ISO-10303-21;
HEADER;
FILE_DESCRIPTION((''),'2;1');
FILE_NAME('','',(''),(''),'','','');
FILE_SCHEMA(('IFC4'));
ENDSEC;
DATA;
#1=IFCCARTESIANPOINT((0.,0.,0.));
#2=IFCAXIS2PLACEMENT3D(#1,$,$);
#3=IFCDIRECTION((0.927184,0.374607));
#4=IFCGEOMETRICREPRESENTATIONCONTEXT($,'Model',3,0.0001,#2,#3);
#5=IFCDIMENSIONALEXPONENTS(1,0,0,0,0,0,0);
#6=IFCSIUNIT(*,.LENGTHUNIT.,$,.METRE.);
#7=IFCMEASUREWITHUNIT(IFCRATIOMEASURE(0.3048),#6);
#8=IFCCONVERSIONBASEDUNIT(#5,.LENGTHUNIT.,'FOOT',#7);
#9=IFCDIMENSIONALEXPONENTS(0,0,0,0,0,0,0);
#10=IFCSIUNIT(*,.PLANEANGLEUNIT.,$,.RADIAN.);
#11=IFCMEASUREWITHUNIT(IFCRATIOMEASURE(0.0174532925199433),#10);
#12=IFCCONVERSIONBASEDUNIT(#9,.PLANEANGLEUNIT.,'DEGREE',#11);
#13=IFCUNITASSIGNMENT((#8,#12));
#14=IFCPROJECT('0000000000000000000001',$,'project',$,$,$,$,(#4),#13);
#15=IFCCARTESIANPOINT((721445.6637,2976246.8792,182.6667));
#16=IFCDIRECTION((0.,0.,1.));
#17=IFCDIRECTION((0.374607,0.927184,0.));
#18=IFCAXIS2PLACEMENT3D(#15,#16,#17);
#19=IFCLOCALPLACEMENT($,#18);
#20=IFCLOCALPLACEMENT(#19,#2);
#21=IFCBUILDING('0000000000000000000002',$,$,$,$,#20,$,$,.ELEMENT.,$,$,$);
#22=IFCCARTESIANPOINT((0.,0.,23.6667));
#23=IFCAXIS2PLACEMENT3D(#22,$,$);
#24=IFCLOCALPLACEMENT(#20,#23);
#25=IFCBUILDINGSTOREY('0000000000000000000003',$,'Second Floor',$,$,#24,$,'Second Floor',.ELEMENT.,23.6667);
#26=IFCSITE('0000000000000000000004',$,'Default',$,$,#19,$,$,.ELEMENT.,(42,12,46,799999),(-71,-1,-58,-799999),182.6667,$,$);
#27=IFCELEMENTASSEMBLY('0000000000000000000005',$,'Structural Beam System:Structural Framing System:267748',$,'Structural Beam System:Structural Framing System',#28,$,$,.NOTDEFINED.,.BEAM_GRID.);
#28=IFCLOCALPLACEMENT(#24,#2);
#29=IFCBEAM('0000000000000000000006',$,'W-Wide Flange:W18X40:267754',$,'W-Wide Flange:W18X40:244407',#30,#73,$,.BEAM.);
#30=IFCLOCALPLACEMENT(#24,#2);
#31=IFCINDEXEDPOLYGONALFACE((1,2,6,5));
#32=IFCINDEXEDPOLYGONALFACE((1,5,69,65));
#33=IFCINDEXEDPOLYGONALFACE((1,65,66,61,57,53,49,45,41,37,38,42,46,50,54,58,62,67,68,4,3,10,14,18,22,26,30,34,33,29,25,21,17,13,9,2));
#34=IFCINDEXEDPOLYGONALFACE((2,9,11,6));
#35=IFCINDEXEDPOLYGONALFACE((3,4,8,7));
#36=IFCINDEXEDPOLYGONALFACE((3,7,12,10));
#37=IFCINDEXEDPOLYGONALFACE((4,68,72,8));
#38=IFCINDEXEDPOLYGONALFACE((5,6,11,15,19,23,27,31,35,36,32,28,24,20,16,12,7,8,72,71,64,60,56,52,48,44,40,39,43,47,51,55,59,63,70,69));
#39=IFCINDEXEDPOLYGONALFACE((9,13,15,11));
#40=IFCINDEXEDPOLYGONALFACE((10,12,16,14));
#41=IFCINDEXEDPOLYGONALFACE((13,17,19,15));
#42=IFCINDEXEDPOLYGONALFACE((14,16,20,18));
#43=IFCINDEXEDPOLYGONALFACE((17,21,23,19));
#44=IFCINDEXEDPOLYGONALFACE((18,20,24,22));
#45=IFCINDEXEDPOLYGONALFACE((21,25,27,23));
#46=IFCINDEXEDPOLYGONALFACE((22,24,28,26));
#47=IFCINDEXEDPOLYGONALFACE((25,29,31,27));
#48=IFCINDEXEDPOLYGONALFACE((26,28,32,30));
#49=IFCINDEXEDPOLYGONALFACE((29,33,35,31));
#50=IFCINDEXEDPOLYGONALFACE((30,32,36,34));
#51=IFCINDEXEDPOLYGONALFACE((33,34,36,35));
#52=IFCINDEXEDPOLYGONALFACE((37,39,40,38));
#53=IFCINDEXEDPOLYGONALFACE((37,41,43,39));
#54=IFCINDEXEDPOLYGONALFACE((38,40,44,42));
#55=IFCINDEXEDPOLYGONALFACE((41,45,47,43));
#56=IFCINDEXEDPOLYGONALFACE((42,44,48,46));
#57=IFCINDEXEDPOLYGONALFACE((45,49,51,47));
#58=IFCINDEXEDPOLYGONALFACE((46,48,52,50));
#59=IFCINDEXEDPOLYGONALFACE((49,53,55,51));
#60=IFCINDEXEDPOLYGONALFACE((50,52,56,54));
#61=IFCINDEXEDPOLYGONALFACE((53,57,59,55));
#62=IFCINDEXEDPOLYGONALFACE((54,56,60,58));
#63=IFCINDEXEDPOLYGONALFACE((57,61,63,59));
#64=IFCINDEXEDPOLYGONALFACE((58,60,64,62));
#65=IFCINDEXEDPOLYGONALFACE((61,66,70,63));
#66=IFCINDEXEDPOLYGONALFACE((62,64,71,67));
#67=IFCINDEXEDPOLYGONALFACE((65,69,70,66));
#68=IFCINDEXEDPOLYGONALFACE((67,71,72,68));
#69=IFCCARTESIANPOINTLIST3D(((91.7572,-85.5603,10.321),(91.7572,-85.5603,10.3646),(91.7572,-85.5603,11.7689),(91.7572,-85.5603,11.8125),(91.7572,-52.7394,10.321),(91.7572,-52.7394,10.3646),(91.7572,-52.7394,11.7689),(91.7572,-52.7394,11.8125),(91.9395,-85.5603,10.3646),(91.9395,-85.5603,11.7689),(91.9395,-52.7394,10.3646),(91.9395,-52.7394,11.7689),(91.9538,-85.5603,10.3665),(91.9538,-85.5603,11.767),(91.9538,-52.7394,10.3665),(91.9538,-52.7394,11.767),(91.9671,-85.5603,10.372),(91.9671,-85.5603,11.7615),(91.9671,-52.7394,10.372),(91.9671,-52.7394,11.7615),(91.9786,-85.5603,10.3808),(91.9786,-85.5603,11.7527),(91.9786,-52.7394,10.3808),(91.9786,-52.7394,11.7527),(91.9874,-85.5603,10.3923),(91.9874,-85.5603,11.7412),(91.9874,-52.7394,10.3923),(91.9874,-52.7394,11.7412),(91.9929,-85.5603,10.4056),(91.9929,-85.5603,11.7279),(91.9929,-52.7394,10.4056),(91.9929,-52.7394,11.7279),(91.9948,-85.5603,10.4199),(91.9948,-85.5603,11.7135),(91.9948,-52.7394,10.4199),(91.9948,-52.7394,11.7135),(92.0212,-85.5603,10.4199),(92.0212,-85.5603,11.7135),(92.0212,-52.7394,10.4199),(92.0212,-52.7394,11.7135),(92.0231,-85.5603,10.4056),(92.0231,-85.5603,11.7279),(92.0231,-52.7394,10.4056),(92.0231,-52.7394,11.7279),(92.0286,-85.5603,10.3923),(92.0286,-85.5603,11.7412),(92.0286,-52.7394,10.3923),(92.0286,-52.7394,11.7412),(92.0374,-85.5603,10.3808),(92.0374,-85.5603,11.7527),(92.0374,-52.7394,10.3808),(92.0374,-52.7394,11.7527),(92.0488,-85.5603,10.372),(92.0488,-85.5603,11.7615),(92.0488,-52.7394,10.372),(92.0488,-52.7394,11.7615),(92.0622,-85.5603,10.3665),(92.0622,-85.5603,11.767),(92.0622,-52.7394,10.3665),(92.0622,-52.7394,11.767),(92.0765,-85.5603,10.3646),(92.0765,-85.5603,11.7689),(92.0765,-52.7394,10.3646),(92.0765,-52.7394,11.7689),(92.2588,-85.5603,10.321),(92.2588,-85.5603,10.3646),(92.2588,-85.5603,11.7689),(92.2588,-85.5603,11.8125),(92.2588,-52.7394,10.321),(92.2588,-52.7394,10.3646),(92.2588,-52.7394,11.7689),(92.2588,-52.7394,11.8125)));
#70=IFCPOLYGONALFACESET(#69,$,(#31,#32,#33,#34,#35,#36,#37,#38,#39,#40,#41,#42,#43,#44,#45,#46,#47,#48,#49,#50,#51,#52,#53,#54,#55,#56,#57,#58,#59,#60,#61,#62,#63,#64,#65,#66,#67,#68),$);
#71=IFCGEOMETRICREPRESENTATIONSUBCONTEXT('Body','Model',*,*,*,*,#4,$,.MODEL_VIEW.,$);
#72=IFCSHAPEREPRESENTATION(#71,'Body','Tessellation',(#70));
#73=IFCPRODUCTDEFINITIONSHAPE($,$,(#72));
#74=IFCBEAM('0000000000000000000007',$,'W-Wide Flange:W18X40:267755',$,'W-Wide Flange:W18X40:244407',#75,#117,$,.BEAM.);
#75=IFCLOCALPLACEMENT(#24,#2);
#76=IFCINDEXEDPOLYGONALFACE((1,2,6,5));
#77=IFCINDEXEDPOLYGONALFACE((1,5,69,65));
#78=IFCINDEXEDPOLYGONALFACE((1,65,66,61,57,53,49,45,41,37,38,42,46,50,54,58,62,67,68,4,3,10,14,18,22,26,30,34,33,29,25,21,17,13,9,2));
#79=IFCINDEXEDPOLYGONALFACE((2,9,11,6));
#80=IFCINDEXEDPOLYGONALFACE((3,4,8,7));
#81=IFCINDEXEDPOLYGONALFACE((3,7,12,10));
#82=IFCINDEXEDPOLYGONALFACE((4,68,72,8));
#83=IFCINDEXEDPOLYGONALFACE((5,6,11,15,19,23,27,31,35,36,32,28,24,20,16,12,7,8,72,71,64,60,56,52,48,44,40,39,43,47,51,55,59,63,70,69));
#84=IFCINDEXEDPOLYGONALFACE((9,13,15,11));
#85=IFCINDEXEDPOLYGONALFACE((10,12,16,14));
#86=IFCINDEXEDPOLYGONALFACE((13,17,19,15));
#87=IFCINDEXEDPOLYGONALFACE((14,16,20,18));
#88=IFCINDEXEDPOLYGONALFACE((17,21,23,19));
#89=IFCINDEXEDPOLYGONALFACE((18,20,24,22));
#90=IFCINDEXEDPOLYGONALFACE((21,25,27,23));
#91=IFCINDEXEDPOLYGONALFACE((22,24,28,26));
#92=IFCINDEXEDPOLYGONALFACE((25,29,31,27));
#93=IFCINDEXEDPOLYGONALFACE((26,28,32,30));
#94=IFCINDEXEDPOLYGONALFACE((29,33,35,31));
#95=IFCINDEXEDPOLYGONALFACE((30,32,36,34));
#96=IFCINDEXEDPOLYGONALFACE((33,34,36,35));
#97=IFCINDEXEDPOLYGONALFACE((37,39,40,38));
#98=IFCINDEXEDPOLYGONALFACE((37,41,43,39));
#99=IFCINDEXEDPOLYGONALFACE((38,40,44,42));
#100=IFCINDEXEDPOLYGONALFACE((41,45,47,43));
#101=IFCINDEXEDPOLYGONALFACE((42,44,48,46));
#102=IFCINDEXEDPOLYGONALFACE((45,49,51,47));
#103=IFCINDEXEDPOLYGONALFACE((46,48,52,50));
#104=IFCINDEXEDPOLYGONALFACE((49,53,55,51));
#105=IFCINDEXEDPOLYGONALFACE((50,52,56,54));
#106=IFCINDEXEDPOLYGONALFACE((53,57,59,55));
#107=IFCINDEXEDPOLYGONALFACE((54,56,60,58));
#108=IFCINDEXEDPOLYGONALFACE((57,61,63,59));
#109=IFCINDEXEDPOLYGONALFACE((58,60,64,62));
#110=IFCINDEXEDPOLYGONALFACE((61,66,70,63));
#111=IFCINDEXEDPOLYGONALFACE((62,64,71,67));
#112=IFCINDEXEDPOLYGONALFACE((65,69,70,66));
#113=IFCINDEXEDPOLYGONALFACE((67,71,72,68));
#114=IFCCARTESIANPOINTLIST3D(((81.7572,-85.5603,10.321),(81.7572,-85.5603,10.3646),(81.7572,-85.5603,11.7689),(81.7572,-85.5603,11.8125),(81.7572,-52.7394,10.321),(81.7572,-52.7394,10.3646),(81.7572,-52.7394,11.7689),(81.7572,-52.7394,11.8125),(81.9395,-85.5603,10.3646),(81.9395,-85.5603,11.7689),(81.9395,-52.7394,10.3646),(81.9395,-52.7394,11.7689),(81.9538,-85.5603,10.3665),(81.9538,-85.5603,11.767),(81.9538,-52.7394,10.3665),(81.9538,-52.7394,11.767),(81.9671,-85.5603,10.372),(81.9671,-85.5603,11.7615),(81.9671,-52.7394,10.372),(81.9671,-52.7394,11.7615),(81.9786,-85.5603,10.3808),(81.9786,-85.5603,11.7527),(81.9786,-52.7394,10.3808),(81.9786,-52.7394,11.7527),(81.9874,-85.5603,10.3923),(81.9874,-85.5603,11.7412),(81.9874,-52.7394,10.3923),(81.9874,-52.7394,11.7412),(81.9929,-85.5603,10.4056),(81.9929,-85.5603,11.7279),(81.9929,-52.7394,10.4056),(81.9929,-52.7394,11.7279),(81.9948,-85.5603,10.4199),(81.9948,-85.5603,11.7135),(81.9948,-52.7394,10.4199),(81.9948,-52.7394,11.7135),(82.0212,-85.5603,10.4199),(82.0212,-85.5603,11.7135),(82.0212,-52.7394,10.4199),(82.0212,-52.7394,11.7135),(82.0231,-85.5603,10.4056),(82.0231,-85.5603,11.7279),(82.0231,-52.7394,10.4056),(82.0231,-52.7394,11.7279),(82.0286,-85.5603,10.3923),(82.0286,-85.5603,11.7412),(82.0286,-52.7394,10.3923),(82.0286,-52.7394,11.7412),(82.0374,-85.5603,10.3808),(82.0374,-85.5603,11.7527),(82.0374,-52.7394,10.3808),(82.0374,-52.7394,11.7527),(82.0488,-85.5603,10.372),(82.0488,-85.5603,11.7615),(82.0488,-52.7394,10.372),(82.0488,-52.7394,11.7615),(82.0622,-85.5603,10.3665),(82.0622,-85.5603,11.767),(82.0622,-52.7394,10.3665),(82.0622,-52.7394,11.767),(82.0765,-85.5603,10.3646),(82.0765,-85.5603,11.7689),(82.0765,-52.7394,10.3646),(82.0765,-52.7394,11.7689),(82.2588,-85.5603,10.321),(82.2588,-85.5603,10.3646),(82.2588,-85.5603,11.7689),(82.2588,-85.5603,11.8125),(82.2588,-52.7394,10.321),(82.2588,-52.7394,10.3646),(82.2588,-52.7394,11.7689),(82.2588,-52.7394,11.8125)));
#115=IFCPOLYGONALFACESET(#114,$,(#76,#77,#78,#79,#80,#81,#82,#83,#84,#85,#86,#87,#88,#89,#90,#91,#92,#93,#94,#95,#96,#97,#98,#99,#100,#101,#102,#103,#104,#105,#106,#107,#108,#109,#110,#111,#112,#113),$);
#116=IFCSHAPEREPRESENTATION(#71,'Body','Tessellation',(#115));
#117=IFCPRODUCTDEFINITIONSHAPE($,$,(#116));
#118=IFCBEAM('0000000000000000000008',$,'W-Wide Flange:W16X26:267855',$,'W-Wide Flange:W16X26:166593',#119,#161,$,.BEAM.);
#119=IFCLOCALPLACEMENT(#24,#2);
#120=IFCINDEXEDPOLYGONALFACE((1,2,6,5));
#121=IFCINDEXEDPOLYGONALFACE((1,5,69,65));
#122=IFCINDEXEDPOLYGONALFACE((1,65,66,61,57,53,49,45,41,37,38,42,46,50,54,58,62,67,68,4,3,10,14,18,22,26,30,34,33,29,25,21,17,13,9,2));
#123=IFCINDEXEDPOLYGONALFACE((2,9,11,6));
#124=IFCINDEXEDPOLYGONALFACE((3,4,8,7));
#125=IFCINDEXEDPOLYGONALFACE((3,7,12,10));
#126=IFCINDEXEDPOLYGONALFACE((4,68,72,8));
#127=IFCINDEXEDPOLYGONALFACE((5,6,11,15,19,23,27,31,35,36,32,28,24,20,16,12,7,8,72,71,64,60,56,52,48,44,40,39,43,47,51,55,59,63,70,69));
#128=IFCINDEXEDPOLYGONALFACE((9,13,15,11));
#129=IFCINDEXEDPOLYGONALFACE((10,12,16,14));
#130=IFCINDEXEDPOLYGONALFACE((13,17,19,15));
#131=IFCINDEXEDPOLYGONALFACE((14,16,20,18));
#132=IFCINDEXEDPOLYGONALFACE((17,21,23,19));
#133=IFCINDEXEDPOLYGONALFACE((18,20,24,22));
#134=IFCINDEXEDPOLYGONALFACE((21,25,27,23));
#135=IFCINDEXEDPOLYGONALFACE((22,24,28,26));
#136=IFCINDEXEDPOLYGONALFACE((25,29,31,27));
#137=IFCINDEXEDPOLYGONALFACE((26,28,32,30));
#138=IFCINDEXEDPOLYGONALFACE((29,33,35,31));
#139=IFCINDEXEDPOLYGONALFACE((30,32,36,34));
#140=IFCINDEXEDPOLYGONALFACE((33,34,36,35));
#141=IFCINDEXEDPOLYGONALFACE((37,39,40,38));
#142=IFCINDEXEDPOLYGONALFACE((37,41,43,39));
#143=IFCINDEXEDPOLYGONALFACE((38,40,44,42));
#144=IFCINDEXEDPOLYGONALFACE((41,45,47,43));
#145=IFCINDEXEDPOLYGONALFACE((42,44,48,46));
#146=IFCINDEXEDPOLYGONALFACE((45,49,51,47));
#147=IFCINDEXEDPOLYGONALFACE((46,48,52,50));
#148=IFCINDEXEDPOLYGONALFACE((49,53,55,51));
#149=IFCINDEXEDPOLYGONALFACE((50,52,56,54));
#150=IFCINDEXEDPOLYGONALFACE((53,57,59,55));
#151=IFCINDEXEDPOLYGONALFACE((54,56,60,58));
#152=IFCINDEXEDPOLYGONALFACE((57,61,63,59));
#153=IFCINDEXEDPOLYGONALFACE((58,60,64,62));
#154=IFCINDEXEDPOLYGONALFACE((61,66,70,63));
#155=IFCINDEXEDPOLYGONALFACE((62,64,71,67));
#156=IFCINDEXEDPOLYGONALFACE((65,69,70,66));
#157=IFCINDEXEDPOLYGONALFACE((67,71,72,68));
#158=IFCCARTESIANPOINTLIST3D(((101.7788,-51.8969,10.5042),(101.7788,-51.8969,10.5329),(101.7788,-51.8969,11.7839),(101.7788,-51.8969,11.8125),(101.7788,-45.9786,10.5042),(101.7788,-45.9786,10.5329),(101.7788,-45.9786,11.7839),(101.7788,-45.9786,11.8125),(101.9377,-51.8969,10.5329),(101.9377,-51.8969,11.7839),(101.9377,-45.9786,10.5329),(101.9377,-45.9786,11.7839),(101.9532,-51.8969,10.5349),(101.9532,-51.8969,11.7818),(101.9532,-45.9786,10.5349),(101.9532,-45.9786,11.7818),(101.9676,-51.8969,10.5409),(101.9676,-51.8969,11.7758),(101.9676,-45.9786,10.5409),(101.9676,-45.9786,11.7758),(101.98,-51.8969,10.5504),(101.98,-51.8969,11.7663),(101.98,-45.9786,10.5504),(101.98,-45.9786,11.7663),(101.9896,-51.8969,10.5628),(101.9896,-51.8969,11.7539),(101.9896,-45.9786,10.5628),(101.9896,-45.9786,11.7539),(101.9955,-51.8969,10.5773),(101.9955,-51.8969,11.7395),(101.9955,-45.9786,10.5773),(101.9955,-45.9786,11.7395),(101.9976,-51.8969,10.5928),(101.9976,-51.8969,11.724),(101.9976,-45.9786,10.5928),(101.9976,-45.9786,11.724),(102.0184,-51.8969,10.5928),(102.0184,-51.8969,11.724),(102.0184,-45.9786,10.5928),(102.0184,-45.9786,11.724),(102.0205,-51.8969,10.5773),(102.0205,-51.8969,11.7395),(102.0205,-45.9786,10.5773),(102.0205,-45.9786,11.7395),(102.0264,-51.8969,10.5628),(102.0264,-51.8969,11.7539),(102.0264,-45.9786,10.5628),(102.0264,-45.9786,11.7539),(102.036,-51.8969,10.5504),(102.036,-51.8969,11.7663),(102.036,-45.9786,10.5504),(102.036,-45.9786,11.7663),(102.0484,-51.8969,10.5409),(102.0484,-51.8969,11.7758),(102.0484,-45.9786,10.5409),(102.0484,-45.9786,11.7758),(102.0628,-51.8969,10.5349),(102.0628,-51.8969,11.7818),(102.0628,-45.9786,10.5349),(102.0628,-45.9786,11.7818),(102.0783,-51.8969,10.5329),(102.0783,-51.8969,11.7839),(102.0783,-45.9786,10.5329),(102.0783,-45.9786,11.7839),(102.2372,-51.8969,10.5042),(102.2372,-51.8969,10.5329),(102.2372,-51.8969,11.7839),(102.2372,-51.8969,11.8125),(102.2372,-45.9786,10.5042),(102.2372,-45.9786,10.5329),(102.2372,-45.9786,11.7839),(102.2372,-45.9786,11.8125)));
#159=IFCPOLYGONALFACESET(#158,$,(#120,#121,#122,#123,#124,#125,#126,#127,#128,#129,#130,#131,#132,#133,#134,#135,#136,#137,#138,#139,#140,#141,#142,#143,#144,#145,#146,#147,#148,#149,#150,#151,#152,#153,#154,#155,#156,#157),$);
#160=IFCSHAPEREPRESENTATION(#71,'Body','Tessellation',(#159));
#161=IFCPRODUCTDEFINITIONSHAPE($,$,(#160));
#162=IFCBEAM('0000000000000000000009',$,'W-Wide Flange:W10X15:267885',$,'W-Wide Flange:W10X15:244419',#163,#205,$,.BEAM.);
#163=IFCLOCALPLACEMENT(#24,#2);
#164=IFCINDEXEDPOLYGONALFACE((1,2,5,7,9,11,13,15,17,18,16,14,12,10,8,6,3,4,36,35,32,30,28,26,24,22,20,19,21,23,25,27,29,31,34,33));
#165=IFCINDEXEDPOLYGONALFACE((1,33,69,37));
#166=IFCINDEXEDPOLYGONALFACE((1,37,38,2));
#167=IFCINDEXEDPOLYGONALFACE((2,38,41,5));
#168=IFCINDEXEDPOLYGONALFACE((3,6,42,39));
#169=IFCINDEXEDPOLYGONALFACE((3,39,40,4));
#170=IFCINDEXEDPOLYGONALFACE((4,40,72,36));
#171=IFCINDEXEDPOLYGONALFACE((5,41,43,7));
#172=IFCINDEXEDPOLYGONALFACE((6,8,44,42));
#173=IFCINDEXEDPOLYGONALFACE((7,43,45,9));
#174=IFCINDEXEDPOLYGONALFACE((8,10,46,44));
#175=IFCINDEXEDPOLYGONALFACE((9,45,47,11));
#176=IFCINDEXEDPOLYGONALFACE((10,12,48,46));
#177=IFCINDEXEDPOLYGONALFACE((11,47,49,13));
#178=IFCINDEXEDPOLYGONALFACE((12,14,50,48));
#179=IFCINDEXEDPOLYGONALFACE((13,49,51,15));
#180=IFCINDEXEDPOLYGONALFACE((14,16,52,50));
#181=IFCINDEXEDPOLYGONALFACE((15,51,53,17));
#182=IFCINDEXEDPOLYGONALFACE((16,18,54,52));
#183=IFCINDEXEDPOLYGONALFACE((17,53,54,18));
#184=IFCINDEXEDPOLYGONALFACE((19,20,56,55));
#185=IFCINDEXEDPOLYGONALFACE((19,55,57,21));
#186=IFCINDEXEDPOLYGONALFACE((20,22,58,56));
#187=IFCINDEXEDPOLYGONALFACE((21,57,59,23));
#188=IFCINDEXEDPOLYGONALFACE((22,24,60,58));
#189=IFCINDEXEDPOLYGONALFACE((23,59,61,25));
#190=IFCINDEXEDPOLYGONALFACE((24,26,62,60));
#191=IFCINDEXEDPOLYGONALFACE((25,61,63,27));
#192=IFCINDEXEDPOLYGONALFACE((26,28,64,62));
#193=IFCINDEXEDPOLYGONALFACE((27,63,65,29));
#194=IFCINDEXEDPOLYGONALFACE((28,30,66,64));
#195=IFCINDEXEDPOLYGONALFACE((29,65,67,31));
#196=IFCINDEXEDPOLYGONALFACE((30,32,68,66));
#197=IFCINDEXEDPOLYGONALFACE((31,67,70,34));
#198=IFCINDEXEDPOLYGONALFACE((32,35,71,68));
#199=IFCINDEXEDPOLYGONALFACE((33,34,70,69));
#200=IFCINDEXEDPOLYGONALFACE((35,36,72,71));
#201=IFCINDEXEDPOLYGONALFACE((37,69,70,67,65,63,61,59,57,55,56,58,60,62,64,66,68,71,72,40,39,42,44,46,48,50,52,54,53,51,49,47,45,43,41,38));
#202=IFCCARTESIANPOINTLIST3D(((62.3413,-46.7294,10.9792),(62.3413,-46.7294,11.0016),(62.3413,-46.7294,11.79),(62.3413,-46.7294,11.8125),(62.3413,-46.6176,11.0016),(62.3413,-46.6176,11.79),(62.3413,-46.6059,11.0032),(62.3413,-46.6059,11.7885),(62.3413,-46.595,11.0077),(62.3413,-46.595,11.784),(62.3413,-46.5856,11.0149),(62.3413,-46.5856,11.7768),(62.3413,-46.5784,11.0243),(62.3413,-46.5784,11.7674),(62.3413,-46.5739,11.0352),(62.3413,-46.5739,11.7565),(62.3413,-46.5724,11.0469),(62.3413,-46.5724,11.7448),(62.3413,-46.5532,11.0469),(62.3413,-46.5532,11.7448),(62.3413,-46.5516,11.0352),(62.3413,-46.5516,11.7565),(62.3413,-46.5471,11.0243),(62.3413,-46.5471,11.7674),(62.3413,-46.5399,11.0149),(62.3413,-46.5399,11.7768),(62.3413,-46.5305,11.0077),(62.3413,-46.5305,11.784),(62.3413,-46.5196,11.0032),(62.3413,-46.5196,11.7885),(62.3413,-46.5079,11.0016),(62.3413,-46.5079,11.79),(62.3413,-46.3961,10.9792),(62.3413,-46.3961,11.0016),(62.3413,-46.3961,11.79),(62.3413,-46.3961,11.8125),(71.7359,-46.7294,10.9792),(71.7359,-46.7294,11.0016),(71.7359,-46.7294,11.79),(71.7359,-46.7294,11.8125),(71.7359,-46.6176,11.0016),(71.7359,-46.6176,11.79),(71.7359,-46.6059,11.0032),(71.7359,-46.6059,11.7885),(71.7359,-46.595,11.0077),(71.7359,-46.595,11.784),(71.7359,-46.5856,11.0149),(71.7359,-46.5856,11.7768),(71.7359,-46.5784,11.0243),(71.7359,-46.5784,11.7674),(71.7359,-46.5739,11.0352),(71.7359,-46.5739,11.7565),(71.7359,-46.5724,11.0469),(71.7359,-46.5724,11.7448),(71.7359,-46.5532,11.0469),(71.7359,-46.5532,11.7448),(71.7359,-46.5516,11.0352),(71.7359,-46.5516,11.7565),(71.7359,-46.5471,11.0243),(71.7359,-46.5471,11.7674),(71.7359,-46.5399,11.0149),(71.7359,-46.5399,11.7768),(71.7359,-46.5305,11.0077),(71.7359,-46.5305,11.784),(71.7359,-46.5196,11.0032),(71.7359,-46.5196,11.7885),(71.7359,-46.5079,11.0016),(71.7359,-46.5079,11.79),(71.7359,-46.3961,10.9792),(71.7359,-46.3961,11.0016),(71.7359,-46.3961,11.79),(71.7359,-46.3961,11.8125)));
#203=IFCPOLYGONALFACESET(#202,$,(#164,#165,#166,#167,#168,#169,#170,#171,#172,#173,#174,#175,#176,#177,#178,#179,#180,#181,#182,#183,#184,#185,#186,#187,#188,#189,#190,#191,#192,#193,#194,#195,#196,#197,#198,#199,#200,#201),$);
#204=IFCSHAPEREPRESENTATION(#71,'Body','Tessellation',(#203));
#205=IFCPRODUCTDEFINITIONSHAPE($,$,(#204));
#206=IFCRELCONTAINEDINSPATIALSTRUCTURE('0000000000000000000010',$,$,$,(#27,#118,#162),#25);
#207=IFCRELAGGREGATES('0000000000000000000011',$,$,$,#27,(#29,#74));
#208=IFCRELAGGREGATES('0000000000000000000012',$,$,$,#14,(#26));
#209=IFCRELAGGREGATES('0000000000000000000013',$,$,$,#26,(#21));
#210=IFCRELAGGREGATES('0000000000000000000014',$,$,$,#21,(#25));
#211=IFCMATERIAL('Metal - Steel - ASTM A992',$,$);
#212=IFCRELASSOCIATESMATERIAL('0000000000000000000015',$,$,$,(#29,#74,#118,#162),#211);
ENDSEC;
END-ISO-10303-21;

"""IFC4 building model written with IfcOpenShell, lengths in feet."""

from ifc_helpers import new_model, entity, si_unit, converted_unit, direction, frame, frame_2d, origin, place, context, subcontext, project, spatial, i_section, extrude, material, element, aggregate, save


model = new_model("IFC4")

# Units and contexts
model_context = context("Model", 3, precision=0.0001, world=origin(), true_north=direction((0.927184, 0.374607)))
body_context = subcontext(model_context, "Body", "Model", "MODEL_VIEW")
ifc_project = project(units=[converted_unit("LENGTHUNIT", "FOOT", entity("IfcRatioMeasure", 0.3048), si_unit("LENGTHUNIT", "METRE"), dimensions=[1, 0, 0, 0, 0, 0, 0]), converted_unit("PLANEANGLEUNIT", "DEGREE", entity("IfcRatioMeasure", 0.0174532925199433), si_unit("PLANEANGLEUNIT", "RADIAN"), dimensions=[0, 0, 0, 0, 0, 0, 0])], contexts=[model_context])

# Site, building, storey
site_placement = place(None, frame((721445.6637, 2976246.8792, 182.6667), z_axis=(0.0, 0.0, 1.0), x_axis=(0.374607, 0.927184, 0.0)))
site = spatial("IfcSite", under=ifc_project, at=site_placement, Name="Default", CompositionType="ELEMENT", RefLatitude=(42, 12, 46, 799999), RefLongitude=(-71, -1, -58, -799999), RefElevation=182.6667)
building_placement = place(site_placement, origin())
building = spatial("IfcBuilding", under=site, at=building_placement, CompositionType="ELEMENT")
storey_placement = place(building_placement, frame((0.0, 0.0, 23.6667)))
storey = spatial("IfcBuildingStorey", under=building, at=storey_placement, Name="Second Floor", LongName="Second Floor", CompositionType="ELEMENT", Elevation=23.6667)

# Shared definitions
ifc_material_1 = material(Name="Metal - Steel - ASTM A992")

# Element assembly, beams
assembly_1_placement = place(storey_placement, origin())
assembly_1 = element("IfcElementAssembly", 1, at=assembly_1_placement, inside=storey, Name="Structural Beam System:Structural Framing System:267748", ObjectType="Structural Beam System:Structural Framing System", AssemblyPlace="NOTDEFINED", PredefinedType="BEAM_GRID")
beam_1_placement = place(assembly_1_placement, frame((92.008, -52.3544, 11.8125), z_axis=(0.0, 0.0, 1.0), x_axis=(0.0, -1.0, 0.0)))
beam_1 = element("IfcBeam", 2, at=beam_1_placement, material=ifc_material_1, Name="W-Wide Flange:W18X40:267754", ObjectType="W-Wide Flange:W18X40:244407", PredefinedType="BEAM", context=body_context, shape_type="SweptSolid", body=[
    extrude(i_section(OverallWidth=0.5016, OverallDepth=1.4915, WebThickness=0.0264, FlangeThickness=0.0436, FilletRadius=0.0553, at=frame_2d((0.0, 0.0), x_axis=(0.0, 1.0))), frame((0.3849, 0.0, -0.7458), z_axis=(1.0, 0.0, 0.0), x_axis=(0.0, 0.0, -1.0)), (0.0, 0.0, 1.0), 32.821),
])
beam_2_placement = place(assembly_1_placement, frame((82.008, -52.3544, 11.8125), z_axis=(0.0, 0.0, 1.0), x_axis=(0.0, -1.0, 0.0)))
beam_2 = element("IfcBeam", 3, at=beam_2_placement, material=ifc_material_1, Name="W-Wide Flange:W18X40:267755", ObjectType="W-Wide Flange:W18X40:244407", PredefinedType="BEAM", context=body_context, shape_type="SweptSolid", body=[
    extrude(i_section(OverallWidth=0.5016, OverallDepth=1.4915, WebThickness=0.0264, FlangeThickness=0.0436, FilletRadius=0.0553, at=frame_2d((0.0, 0.0), x_axis=(0.0, 1.0))), frame((0.3849, 0.0, -0.7458), z_axis=(1.0, 0.0, 0.0), x_axis=(0.0, 0.0, -1.0)), (0.0, 0.0, 1.0), 32.821),
])
aggregate(assembly_1, [beam_1, beam_2])

# Beams
beam_3_placement = place(storey_placement, frame((102.008, -52.3544, 11.8125), z_axis=(0.0, 0.0, 1.0), x_axis=(0.0, 1.0, 0.0)))
element("IfcBeam", 4, at=beam_3_placement, inside=storey, material=ifc_material_1, Name="W-Wide Flange:W16X26:267855", ObjectType="W-Wide Flange:W16X26:166593", PredefinedType="BEAM", context=body_context, shape_type="SweptSolid", body=[
    extrude(i_section(OverallWidth=0.4583, OverallDepth=1.3083, WebThickness=0.0208, FlangeThickness=0.0286, FilletRadius=0.0599, at=frame_2d((0.0, 0.0), x_axis=(0.0, 1.0))), frame((0.4575, 0.0, -0.6541), z_axis=(1.0, 0.0, 0.0), x_axis=(0.0, 0.0, -1.0)), (0.0, 0.0, 1.0), 5.9183),
])
beam_4_placement = place(storey_placement, frame((62.008, -46.5628, 11.8125)))
element("IfcBeam", 5, at=beam_4_placement, inside=storey, material=ifc_material_1, Name="W-Wide Flange:W10X15:267885", ObjectType="W-Wide Flange:W10X15:244419", PredefinedType="BEAM", context=body_context, shape_type="SweptSolid", body=[
    extrude(i_section(OverallWidth=0.3333, OverallDepth=0.8333, WebThickness=0.0192, FlangeThickness=0.0225, FilletRadius=0.0452, at=frame_2d((0.0, 0.0), x_axis=(0.0, 1.0))), frame((0.3333, 0.0, -0.4167), z_axis=(1.0, 0.0, 0.0), x_axis=(0.0, 0.0, -1.0)), (0.0, 0.0, 1.0), 9.3945),
])

save(model, "model.ifc")
